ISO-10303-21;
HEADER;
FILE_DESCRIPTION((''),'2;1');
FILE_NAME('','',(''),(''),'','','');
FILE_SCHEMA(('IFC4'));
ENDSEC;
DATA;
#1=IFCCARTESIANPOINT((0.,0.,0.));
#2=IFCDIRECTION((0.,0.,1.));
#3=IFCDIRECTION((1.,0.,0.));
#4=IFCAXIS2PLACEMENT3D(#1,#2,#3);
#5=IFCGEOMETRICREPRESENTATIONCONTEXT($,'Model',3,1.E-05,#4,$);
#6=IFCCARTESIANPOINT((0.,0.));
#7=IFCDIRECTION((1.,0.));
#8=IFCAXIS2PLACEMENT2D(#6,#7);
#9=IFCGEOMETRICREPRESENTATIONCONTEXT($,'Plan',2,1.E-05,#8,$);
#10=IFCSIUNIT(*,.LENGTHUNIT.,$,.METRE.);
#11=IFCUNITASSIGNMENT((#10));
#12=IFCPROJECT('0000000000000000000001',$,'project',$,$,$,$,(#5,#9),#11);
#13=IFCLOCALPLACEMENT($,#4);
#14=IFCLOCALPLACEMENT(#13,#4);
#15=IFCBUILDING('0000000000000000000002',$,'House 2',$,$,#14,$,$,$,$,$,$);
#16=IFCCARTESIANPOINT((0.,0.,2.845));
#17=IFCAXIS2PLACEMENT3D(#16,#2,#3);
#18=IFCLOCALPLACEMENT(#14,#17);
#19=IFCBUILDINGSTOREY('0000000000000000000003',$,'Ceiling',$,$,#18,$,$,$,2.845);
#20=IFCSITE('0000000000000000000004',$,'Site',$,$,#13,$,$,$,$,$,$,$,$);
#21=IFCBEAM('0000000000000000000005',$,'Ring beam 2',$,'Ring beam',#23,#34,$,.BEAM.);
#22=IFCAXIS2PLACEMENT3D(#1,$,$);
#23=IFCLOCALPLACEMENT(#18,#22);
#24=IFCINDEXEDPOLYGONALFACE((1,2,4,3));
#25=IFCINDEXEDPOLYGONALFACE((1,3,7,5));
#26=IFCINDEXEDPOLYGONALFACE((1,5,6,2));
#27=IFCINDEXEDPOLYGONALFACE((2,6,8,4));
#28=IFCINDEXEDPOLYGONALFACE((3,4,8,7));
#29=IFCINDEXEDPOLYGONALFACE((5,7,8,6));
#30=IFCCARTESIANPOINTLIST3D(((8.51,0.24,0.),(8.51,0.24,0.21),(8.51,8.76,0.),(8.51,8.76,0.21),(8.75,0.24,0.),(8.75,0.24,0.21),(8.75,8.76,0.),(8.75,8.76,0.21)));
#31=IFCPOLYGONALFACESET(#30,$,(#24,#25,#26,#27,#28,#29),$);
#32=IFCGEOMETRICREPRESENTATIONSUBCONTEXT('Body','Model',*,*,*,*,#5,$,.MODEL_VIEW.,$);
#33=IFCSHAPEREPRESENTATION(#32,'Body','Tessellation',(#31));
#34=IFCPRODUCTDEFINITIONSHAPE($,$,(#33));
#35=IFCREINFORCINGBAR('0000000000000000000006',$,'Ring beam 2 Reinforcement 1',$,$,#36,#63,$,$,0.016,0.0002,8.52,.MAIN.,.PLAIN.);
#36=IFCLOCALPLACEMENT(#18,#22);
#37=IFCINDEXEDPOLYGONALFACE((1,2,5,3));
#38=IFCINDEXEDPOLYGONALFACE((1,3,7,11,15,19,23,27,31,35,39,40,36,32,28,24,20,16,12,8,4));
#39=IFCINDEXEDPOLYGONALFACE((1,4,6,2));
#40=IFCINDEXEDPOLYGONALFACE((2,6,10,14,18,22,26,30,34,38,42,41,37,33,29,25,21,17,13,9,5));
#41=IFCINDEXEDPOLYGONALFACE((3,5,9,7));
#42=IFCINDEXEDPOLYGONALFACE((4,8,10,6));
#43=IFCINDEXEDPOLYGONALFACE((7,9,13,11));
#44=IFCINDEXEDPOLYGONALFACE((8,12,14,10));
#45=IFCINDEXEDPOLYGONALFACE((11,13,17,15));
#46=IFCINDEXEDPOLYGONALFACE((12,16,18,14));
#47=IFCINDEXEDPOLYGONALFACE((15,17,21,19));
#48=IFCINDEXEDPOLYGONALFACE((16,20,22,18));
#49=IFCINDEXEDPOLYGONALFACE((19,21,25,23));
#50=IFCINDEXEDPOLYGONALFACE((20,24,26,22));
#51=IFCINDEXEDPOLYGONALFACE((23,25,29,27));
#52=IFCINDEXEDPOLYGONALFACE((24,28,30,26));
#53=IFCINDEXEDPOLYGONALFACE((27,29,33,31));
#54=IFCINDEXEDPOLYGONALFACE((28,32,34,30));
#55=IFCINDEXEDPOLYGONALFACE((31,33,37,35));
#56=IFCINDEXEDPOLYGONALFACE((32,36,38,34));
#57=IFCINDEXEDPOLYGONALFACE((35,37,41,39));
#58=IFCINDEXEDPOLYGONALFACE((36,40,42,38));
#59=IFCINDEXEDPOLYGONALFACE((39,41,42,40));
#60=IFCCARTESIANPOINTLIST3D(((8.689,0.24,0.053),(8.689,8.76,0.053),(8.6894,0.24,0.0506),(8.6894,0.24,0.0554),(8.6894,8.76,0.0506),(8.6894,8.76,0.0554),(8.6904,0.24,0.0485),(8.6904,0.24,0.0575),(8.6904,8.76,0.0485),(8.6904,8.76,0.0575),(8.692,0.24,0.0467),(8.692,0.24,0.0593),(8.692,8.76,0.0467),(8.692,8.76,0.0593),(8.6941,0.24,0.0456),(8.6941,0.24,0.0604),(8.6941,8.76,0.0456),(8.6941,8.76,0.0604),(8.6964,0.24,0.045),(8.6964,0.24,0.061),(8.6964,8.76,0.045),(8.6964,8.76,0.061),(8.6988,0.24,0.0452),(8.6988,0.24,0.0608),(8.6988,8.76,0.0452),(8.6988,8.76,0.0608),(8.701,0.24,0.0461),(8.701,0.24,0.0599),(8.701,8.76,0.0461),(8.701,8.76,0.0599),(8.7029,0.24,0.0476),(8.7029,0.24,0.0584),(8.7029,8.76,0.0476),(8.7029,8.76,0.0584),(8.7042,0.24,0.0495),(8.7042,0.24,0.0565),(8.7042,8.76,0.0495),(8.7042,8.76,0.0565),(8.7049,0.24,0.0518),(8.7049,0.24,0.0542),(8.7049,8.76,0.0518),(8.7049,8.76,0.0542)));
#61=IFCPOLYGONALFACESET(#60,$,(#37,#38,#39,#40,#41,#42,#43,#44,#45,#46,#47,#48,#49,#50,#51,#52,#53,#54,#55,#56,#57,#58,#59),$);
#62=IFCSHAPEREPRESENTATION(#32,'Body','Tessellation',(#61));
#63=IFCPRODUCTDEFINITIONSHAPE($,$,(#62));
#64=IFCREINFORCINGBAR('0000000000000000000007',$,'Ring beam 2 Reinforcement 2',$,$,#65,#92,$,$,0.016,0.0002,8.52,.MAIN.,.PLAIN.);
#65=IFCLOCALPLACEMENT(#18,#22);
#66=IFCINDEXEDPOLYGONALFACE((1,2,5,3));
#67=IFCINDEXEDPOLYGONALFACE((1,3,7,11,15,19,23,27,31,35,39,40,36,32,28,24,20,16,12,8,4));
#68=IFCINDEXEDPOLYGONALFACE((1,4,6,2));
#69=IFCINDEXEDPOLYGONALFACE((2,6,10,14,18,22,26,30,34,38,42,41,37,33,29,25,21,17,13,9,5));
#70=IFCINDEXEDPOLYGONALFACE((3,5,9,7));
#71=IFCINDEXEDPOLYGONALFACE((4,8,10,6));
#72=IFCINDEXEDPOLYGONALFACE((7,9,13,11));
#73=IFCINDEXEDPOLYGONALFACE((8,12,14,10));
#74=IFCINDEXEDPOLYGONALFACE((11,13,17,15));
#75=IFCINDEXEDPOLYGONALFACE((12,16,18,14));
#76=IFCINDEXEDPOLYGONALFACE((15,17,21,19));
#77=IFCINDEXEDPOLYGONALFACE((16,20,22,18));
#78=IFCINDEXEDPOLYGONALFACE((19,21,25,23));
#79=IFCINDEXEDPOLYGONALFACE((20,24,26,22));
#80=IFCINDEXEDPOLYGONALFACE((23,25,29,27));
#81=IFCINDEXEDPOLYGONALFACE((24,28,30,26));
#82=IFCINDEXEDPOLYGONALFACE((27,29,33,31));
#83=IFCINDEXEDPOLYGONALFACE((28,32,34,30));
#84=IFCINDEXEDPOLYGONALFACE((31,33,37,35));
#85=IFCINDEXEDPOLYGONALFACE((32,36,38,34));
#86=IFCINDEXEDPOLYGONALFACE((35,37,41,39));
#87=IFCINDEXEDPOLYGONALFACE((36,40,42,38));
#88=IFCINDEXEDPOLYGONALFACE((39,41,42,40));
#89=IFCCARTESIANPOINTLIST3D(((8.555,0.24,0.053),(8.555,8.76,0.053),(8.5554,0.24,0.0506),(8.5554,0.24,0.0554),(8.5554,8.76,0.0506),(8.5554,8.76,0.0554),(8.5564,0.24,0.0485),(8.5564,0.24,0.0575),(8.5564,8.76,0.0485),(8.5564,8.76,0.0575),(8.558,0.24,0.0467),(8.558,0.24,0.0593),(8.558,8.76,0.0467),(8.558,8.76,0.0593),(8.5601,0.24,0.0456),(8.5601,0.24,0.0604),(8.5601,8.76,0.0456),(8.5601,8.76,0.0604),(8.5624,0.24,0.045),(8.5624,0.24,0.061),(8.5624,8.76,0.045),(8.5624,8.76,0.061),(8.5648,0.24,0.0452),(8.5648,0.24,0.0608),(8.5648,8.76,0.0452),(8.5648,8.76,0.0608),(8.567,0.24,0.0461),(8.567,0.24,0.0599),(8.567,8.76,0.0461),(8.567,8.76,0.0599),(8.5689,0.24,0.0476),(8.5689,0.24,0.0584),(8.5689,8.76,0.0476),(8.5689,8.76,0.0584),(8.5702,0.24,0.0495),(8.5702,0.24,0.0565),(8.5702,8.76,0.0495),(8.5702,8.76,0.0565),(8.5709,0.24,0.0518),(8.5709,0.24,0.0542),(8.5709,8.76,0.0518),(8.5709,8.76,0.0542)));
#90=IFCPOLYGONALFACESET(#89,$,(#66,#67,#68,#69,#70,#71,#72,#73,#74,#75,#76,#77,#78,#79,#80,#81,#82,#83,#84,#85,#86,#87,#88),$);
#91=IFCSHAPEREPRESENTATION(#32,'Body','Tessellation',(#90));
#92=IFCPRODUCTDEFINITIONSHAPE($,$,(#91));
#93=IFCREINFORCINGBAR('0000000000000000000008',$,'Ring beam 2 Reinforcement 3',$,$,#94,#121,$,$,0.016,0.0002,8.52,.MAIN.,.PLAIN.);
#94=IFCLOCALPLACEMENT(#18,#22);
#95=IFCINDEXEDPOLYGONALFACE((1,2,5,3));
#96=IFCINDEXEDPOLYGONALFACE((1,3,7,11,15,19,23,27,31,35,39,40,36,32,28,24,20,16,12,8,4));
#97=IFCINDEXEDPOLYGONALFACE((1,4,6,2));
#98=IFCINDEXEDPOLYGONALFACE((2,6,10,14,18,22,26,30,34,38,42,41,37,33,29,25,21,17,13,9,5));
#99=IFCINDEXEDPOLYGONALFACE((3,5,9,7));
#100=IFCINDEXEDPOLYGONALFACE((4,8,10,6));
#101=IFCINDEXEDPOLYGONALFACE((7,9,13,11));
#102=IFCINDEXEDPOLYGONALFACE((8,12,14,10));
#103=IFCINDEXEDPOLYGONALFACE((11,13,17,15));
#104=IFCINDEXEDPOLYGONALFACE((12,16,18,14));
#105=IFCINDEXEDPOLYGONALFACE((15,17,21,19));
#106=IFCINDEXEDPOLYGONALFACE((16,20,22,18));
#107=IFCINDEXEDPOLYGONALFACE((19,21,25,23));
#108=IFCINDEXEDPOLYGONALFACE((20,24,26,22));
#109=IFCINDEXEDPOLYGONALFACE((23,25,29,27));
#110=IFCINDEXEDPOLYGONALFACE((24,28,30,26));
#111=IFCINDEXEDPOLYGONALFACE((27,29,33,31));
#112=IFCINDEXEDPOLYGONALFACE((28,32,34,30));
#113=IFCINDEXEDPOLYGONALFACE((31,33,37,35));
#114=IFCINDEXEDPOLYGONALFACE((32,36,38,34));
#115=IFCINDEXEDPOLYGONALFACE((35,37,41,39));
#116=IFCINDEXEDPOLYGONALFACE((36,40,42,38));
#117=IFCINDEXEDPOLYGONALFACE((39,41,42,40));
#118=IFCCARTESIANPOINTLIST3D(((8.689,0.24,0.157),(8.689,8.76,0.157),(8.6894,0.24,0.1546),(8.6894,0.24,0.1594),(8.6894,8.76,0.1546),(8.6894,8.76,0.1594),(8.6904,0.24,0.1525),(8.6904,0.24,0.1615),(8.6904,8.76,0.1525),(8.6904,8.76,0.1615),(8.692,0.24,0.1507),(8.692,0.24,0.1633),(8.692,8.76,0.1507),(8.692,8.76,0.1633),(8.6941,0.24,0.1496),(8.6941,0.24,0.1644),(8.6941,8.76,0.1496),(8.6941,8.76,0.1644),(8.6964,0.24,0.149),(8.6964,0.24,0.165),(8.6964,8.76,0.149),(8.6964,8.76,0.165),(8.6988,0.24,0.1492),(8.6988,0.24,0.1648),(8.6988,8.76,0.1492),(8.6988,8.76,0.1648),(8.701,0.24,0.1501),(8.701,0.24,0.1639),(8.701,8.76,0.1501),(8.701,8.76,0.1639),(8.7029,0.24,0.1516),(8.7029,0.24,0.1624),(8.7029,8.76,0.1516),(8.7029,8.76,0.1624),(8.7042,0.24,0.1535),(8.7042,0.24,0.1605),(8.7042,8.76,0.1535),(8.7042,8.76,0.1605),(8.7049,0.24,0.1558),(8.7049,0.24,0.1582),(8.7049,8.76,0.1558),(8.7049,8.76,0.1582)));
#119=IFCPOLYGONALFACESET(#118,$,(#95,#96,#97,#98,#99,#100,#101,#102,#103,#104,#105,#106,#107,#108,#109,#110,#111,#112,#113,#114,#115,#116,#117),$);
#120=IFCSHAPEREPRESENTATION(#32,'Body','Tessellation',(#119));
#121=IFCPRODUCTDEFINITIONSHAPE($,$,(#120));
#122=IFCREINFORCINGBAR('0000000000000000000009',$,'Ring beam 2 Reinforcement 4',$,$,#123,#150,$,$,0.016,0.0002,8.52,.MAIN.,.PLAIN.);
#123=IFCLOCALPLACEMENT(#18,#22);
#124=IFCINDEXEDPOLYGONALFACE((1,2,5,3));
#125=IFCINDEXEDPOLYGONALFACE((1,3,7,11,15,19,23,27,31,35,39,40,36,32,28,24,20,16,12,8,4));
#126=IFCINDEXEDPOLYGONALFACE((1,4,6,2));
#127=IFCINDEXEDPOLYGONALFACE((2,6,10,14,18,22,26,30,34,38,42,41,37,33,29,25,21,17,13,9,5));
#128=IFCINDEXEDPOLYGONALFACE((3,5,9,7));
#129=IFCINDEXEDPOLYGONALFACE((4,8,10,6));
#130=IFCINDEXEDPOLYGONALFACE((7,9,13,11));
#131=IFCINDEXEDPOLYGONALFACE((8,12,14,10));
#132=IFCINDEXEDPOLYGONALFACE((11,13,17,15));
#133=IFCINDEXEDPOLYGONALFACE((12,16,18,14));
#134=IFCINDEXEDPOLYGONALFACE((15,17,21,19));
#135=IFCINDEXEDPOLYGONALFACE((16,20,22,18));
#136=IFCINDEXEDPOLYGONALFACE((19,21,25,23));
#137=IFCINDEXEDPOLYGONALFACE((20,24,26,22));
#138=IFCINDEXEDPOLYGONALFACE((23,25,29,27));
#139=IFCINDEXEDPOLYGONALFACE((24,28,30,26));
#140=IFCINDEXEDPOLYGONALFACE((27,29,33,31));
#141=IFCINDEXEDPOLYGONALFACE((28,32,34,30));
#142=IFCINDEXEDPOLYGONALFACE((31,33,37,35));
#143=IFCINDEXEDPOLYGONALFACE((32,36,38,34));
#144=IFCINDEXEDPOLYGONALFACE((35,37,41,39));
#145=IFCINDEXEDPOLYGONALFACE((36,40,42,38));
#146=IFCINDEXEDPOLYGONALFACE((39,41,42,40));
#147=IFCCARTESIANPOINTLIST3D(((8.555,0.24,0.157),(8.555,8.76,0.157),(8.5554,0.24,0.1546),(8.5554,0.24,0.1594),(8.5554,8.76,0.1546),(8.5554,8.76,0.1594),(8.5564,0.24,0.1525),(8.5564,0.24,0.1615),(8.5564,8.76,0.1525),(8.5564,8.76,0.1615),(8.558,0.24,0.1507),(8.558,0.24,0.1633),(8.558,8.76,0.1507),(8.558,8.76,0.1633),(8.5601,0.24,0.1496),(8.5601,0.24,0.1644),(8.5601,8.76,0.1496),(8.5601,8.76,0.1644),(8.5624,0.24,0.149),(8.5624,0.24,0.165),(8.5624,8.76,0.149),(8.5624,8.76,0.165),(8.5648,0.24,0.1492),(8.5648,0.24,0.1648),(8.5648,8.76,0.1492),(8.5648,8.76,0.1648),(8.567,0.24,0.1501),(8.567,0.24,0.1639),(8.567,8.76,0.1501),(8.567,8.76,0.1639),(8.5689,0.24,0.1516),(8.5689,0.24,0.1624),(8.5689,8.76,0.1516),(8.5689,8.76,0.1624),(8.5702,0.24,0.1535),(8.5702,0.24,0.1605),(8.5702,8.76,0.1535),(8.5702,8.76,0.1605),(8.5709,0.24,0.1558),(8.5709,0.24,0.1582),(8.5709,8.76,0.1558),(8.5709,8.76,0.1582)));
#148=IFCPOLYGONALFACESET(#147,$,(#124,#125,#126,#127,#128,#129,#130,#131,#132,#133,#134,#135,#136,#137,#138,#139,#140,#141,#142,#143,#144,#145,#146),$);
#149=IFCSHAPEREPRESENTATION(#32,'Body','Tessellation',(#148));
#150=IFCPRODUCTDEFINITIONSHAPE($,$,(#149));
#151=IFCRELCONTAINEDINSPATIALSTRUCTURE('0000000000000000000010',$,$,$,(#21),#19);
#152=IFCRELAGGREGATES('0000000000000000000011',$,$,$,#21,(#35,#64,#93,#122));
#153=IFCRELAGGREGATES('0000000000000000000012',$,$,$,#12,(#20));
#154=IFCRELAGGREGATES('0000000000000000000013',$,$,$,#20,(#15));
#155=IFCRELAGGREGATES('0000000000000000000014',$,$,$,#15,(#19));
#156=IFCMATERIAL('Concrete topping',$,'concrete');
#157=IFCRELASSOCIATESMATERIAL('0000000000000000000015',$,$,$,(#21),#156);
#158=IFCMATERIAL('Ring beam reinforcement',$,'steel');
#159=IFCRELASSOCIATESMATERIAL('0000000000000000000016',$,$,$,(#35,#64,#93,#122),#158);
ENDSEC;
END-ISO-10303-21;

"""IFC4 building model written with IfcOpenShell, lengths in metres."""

from ifc_helpers import new_model, si_unit, frame, origin_with_axes, origin_2d, origin_2d_with_axis, place, context, subcontext, project, spatial, circle_curve, rectangle, outline, extrude, material, element, aggregate, save


model = new_model("IFC4")

# Units and contexts
model_context = context("Model", 3, precision=1e-05, world=origin_with_axes())
plan_context = context("Plan", 2, precision=1e-05, world=origin_2d_with_axis())
body_context_1 = subcontext(model_context, "Body", "Model", "MODEL_VIEW")
ifc_project = project(units=[si_unit("LENGTHUNIT", "METRE")], contexts=[model_context, plan_context])

# Site, building, storey
site_placement = place(None, origin_with_axes())
building_placement = place(site_placement, origin_with_axes())
storey_placement = place(building_placement, frame((0.0, 0.0, 2.845), z_axis=(0.0, 0.0, 1.0), x_axis=(1.0, 0.0, 0.0)))
site = spatial("IfcSite", under=ifc_project, at=site_placement, Name="Site")
building = spatial("IfcBuilding", under=site, at=building_placement, Name="House 2")
storey = spatial("IfcBuildingStorey", under=building, at=storey_placement, Name="Ceiling", Elevation=2.845)

# Beam
ifc_material_1 = material(Name="Concrete topping", Category="concrete")
beam_1_placement = place(storey_placement, frame((8.63, 0.24, 0.105), z_axis=(0.0, 0.0, 1.0), x_axis=(0.0, 1.0, 0.0)))
beam_1 = element("IfcBeam", 1, at=beam_1_placement, inside=storey, material=ifc_material_1, Name="Ring beam 2", ObjectType="Ring beam", PredefinedType="BEAM", context=body_context_1, shape_type="SweptSolid", body=[
    extrude(rectangle(XDim=0.24, YDim=0.21), frame((0.0, 0.0, 0.0), z_axis=(1.0, 0.0, 0.0), x_axis=(0.0, 1.0, 0.0)), (0.0, 0.0, 1.0), 8.52),
])

# Reinforcing bars
ifc_material_2 = material(Name="Ring beam reinforcement", Category="steel")
reinforcing_bar_1_placement = place(beam_1_placement, frame((0.0, -0.067, -0.052), z_axis=(0.0, 0.0, 1.0), x_axis=(1.0, 0.0, 0.0)))
reinforcing_bar_1 = element("IfcReinforcingBar", 2, at=reinforcing_bar_1_placement, material=ifc_material_2, Name="Ring beam 2 Reinforcement 1", BarLength=8.52, BarSurface="PLAIN", CrossSectionArea=0.0002, NominalDiameter=0.016, PredefinedType="MAIN", context=body_context_1, shape_type="SweptSolid", body=[
    extrude(outline(circle_curve(origin_2d(), 0.008)), frame((0.0, 0.0, 0.0), z_axis=(1.0, 0.0, 0.0), x_axis=(0.0, 1.0, 0.0)), (0.0, 0.0, 1.0), 8.52),
])
reinforcing_bar_2_placement = place(beam_1_placement, frame((0.0, 0.067, -0.052), z_axis=(0.0, 0.0, 1.0), x_axis=(1.0, 0.0, 0.0)))
reinforcing_bar_2 = element("IfcReinforcingBar", 3, at=reinforcing_bar_2_placement, material=ifc_material_2, Name="Ring beam 2 Reinforcement 2", BarLength=8.52, BarSurface="PLAIN", CrossSectionArea=0.0002, NominalDiameter=0.016, PredefinedType="MAIN", context=body_context_1, shape_type="SweptSolid", body=[
    extrude(outline(circle_curve(origin_2d(), 0.008)), frame((0.0, 0.0, 0.0), z_axis=(1.0, 0.0, 0.0), x_axis=(0.0, 1.0, 0.0)), (0.0, 0.0, 1.0), 8.52),
])
reinforcing_bar_3_placement = place(beam_1_placement, frame((0.0, -0.067, 0.052), z_axis=(0.0, 0.0, 1.0), x_axis=(1.0, 0.0, 0.0)))
reinforcing_bar_3 = element("IfcReinforcingBar", 4, at=reinforcing_bar_3_placement, material=ifc_material_2, Name="Ring beam 2 Reinforcement 3", BarLength=8.52, BarSurface="PLAIN", CrossSectionArea=0.0002, NominalDiameter=0.016, PredefinedType="MAIN", context=body_context_1, shape_type="SweptSolid", body=[
    extrude(outline(circle_curve(origin_2d(), 0.008)), frame((0.0, 0.0, 0.0), z_axis=(1.0, 0.0, 0.0), x_axis=(0.0, 1.0, 0.0)), (0.0, 0.0, 1.0), 8.52),
])
reinforcing_bar_4_placement = place(beam_1_placement, frame((0.0, 0.067, 0.052), z_axis=(0.0, 0.0, 1.0), x_axis=(1.0, 0.0, 0.0)))
reinforcing_bar_4 = element("IfcReinforcingBar", 5, at=reinforcing_bar_4_placement, material=ifc_material_2, Name="Ring beam 2 Reinforcement 4", BarLength=8.52, BarSurface="PLAIN", CrossSectionArea=0.0002, NominalDiameter=0.016, PredefinedType="MAIN", context=body_context_1, shape_type="SweptSolid", body=[
    extrude(outline(circle_curve(origin_2d(), 0.008)), frame((0.0, 0.0, 0.0), z_axis=(1.0, 0.0, 0.0), x_axis=(0.0, 1.0, 0.0)), (0.0, 0.0, 1.0), 8.52),
])
aggregate(beam_1, [reinforcing_bar_1, reinforcing_bar_2, reinforcing_bar_3, reinforcing_bar_4])

save(model, "model.ifc")
